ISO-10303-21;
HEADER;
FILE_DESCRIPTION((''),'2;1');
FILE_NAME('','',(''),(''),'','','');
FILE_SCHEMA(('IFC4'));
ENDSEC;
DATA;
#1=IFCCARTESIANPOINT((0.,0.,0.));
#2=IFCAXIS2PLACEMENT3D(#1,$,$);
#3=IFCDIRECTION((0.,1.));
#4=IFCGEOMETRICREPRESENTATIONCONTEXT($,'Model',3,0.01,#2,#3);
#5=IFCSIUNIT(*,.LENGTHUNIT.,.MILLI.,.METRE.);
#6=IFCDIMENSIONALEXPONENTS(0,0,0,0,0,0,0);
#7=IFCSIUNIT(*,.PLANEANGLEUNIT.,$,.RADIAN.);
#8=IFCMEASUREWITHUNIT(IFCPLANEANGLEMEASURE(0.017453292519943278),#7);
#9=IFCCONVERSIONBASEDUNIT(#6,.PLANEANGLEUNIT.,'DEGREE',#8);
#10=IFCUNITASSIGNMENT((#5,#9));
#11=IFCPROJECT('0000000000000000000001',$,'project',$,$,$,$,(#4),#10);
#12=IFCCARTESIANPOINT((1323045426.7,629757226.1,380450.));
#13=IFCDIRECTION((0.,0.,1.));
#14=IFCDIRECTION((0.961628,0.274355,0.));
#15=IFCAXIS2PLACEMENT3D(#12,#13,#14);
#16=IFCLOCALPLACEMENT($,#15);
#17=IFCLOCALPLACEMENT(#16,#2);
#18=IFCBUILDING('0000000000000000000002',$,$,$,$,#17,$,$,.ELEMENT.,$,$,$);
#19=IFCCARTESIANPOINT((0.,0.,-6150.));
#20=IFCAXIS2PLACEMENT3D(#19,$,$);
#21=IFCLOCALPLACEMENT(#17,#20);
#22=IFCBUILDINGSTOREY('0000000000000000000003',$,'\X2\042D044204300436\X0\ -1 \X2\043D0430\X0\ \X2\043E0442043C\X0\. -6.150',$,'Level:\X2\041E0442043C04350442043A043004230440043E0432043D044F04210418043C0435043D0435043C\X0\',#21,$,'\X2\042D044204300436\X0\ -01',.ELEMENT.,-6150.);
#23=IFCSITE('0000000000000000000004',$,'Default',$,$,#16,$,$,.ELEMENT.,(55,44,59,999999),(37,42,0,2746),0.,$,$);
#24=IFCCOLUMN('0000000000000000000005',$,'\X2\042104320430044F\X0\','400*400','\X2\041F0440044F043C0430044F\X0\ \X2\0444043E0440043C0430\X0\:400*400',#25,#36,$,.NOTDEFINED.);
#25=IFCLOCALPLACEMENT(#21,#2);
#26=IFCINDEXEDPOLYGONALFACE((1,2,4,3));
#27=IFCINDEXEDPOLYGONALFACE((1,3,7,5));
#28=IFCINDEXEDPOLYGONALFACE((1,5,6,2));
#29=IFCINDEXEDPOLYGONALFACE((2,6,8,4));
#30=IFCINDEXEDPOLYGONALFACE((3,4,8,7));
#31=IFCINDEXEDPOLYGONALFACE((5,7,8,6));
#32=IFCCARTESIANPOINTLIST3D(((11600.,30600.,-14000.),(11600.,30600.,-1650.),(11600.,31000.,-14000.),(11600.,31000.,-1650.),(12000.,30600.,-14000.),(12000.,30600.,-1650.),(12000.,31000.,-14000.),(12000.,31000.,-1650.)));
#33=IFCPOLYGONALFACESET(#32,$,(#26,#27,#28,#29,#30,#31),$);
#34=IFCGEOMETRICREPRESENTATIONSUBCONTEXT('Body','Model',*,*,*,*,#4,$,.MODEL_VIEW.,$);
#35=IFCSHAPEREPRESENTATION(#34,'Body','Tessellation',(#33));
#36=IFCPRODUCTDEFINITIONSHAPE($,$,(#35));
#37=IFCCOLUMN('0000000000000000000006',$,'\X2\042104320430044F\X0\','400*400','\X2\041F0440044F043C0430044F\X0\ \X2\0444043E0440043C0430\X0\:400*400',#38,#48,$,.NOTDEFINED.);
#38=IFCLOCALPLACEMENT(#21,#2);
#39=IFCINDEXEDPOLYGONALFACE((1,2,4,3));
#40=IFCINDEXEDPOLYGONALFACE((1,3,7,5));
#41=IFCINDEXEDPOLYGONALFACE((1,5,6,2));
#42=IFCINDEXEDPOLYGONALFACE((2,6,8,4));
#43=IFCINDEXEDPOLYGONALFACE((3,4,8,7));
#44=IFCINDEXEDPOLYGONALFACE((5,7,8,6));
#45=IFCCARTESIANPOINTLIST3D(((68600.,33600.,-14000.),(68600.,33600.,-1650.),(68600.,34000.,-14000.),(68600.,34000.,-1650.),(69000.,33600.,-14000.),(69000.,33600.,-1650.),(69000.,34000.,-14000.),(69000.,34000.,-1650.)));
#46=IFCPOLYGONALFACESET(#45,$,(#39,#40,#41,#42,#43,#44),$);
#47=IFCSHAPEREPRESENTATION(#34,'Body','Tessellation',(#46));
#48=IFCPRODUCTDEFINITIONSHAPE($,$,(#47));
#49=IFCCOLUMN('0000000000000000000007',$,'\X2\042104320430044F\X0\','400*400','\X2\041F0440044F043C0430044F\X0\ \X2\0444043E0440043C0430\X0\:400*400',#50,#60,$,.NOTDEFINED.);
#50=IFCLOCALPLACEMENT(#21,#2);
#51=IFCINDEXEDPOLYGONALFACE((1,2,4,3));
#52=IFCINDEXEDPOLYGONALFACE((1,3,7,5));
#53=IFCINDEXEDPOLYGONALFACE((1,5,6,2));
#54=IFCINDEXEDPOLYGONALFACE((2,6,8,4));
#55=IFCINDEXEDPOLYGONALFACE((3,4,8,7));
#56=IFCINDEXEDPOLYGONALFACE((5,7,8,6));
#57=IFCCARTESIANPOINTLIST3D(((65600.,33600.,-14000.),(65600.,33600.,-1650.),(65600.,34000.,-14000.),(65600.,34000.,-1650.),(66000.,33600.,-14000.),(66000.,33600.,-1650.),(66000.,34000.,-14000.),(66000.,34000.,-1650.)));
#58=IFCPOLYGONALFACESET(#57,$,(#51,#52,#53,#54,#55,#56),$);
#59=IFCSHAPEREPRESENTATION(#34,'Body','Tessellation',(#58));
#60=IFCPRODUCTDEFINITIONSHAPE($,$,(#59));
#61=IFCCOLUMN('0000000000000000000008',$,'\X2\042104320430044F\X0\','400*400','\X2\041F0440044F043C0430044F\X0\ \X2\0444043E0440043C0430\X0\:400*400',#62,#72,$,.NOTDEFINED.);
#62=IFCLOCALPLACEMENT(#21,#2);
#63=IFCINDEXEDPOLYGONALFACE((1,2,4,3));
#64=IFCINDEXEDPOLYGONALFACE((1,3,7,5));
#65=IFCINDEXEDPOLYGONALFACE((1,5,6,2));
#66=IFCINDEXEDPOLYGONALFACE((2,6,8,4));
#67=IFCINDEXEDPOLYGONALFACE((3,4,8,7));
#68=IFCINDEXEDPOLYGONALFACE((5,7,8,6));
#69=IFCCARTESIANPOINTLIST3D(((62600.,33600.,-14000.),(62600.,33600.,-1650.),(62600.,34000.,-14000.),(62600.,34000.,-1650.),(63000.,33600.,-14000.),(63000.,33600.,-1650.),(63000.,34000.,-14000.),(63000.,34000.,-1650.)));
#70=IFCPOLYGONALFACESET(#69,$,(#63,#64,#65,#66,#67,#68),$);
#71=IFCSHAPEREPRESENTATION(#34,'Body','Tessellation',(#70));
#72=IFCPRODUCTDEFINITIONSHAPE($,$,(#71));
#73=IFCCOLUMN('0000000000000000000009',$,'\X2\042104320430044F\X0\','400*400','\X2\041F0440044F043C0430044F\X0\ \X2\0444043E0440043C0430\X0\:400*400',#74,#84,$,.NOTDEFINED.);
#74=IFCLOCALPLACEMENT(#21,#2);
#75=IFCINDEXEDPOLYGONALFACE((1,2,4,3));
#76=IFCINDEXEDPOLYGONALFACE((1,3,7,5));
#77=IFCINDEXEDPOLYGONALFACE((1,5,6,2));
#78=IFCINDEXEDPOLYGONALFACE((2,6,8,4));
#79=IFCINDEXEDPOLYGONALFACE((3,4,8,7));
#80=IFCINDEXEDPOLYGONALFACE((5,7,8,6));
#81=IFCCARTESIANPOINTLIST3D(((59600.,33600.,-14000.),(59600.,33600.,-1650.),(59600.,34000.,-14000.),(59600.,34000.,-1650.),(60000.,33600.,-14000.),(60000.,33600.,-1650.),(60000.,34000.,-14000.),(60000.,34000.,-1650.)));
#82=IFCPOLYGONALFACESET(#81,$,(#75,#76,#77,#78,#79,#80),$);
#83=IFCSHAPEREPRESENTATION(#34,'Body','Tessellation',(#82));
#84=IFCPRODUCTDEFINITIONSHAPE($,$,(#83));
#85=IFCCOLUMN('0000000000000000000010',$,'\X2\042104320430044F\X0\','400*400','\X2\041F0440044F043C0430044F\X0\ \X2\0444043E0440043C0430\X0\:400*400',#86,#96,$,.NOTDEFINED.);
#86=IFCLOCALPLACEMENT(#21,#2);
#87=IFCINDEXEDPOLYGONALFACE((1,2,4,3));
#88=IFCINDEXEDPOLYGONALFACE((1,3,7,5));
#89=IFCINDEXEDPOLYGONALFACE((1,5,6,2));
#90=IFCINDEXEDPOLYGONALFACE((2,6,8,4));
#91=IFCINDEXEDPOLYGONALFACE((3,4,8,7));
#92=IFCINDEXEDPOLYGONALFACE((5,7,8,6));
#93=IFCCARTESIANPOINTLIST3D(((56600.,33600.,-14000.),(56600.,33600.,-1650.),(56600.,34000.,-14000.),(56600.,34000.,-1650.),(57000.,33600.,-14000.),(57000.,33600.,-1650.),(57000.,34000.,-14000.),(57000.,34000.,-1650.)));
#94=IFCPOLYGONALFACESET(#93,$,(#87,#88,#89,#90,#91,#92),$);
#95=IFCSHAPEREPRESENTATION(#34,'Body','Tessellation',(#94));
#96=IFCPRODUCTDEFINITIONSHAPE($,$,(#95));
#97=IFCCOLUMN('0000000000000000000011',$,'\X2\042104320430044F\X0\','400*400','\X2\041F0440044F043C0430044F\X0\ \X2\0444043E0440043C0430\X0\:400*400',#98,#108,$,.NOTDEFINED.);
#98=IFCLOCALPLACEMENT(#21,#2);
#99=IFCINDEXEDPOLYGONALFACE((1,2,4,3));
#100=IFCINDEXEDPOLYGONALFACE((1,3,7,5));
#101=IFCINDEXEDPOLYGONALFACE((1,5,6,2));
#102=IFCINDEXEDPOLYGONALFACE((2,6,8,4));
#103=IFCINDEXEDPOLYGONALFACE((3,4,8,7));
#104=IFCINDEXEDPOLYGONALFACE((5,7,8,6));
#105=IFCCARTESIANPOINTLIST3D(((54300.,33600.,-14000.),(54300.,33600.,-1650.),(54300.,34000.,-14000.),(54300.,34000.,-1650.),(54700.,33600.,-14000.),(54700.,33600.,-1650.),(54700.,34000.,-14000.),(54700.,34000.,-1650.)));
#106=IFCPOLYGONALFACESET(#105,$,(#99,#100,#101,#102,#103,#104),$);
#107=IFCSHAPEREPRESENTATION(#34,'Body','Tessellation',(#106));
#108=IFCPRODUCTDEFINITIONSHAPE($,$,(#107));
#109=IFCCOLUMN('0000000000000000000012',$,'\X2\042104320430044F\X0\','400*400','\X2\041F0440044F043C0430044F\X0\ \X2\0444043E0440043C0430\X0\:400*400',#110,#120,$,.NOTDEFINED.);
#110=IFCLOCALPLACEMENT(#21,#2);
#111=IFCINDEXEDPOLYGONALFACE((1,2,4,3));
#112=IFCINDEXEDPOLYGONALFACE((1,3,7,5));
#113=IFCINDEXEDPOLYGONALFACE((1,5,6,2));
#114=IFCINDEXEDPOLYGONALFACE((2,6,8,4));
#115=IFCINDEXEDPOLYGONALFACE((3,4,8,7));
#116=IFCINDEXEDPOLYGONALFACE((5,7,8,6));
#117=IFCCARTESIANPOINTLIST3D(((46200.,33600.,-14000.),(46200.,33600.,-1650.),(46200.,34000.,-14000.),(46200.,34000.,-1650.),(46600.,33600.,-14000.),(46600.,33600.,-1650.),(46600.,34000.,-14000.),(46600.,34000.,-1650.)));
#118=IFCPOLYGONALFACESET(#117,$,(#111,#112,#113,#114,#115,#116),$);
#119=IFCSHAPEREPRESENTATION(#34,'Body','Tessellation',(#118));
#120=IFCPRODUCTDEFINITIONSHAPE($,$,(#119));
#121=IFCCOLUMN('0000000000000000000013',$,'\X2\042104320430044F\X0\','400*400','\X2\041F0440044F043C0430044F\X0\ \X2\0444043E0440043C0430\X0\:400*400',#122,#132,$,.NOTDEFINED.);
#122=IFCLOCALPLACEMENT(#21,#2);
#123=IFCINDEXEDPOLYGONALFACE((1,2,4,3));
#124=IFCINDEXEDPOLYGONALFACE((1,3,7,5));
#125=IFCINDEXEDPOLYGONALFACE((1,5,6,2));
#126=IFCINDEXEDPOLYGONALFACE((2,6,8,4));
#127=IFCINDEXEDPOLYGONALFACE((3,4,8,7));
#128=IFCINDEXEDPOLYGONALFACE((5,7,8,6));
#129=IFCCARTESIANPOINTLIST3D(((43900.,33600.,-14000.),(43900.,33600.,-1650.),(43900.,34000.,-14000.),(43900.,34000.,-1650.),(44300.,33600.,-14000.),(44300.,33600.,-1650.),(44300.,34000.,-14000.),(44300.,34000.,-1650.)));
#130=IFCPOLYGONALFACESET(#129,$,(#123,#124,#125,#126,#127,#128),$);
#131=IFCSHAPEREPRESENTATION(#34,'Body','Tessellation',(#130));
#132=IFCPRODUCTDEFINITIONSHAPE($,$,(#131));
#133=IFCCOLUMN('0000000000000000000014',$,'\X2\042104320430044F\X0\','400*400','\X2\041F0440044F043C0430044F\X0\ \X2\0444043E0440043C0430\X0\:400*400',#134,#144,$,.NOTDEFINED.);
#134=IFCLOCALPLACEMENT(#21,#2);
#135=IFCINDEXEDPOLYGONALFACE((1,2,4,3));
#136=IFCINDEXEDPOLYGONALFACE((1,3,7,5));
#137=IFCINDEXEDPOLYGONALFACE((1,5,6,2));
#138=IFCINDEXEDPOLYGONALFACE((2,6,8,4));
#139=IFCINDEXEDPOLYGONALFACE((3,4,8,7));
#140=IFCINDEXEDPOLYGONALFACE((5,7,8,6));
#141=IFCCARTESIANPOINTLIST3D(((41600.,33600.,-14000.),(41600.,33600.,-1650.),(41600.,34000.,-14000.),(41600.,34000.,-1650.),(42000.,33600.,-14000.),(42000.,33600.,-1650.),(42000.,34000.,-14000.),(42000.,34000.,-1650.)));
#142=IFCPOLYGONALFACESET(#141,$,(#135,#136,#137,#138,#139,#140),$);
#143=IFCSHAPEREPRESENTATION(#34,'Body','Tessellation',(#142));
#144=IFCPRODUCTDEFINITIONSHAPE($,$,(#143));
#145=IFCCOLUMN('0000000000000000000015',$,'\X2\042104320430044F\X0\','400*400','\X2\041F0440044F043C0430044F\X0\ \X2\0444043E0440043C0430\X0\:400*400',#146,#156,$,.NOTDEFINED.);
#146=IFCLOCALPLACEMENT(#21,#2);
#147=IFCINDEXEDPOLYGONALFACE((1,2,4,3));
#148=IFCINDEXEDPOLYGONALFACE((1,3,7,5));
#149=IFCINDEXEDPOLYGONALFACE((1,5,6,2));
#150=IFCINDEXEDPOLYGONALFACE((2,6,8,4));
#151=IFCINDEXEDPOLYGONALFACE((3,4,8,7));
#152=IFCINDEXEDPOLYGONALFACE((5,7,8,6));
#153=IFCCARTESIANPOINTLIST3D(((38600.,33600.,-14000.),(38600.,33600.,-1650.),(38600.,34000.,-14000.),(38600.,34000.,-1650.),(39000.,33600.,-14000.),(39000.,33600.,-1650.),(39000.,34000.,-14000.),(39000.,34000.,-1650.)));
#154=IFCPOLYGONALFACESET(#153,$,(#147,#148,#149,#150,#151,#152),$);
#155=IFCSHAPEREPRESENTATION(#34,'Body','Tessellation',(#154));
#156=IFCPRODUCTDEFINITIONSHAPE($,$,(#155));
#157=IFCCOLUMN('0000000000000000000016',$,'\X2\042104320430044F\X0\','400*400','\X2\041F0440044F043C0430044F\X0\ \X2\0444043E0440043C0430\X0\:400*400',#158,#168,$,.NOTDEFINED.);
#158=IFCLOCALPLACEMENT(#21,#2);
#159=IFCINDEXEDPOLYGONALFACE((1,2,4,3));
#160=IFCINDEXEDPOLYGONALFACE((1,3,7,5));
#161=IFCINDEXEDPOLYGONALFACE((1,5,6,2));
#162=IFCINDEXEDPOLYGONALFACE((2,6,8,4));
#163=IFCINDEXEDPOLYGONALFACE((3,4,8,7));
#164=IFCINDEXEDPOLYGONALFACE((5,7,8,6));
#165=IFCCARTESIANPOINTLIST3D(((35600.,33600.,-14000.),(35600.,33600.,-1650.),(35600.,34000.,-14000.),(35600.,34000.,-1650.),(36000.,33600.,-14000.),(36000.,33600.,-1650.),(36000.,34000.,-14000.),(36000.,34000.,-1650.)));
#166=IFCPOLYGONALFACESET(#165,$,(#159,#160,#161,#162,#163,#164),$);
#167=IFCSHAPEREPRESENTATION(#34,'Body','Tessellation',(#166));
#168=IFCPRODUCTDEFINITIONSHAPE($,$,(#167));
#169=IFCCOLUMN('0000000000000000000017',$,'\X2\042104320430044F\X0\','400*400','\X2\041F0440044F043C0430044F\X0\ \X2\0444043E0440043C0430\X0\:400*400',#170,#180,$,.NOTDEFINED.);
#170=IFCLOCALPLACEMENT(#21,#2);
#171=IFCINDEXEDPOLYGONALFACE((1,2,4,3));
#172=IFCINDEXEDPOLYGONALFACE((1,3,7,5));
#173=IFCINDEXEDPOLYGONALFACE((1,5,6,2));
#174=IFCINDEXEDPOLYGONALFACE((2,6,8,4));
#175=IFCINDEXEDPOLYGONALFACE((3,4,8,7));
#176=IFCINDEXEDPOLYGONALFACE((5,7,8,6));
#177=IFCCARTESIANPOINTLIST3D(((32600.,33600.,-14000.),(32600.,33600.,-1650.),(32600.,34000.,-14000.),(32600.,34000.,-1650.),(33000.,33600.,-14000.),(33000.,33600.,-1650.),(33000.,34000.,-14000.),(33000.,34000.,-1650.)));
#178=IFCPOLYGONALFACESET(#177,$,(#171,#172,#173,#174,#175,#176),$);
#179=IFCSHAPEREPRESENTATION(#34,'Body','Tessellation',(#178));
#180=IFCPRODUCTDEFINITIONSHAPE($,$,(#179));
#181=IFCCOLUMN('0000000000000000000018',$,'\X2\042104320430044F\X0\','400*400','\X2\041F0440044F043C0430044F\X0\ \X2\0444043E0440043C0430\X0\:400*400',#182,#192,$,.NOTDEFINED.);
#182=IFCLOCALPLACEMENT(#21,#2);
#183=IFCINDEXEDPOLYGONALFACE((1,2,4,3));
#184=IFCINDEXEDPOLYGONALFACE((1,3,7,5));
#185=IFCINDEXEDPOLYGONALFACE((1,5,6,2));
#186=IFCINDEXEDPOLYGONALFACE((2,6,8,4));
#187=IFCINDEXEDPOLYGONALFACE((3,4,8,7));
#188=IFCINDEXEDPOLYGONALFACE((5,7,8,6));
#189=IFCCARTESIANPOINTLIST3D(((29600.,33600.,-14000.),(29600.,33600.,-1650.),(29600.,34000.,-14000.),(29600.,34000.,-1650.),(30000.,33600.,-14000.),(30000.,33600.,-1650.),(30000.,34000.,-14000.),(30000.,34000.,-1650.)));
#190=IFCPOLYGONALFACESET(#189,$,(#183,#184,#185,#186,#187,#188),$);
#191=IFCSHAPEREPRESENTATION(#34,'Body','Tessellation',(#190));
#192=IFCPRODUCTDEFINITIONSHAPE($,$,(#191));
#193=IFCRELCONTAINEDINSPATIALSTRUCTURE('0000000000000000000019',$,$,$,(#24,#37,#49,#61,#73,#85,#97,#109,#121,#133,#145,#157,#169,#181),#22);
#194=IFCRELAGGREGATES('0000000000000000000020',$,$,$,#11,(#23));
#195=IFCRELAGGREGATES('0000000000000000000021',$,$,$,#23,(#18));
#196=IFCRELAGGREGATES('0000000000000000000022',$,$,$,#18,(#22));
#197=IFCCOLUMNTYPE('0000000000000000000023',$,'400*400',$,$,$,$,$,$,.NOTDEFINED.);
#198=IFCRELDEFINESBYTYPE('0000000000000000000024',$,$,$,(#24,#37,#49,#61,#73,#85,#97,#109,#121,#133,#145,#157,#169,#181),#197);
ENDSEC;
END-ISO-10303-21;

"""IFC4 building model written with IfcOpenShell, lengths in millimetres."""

from ifc_helpers import new_model, entity, si_unit, converted_unit, direction, frame, origin, place, context, subcontext, project, spatial, indexed_curve, outline, extrude, type_object, element, save


model = new_model("IFC4")

# Units and contexts
model_context = context("Model", 3, precision=0.01, world=origin(), true_north=direction((0.0, 1.0)))
body_context = subcontext(model_context, "Body", "Model", "MODEL_VIEW")
ifc_project = project(units=[si_unit("LENGTHUNIT", "METRE", prefix="MILLI"), converted_unit("PLANEANGLEUNIT", "DEGREE", entity("IfcPlaneAngleMeasure", 0.017453292519943278), si_unit("PLANEANGLEUNIT", "RADIAN"), dimensions=[0, 0, 0, 0, 0, 0, 0])], contexts=[model_context])

# Site, building, storey
site_placement = place(None, frame((1323045426.7, 629757226.1, 380450.0), z_axis=(0.0, 0.0, 1.0), x_axis=(0.961628, 0.274355, 0.0)))
site = spatial("IfcSite", under=ifc_project, at=site_placement, Name="Default", CompositionType="ELEMENT", RefLatitude=(55, 44, 59, 999999), RefLongitude=(37, 42, 0, 2746), RefElevation=0.0)
building_placement = place(site_placement, origin())
building = spatial("IfcBuilding", under=site, at=building_placement, CompositionType="ELEMENT")
storey_placement = place(building_placement, frame((0.0, 0.0, -6150.0)))
storey = spatial("IfcBuildingStorey", under=building, at=storey_placement, Name="Этаж -1 на отм. -6.150", ObjectType="Level:ОтметкаУровняСИменем", LongName="Этаж -01", CompositionType="ELEMENT", Elevation=-6150.0)

# Columns
column_type = type_object("IfcColumnType", Name="400*400", PredefinedType="NOTDEFINED")
column_1_placement = place(storey_placement, origin())
element("IfcColumn", 1, at=column_1_placement, inside=storey, type_object=column_type, Name="Свая", Description="400*400", ObjectType="Прямая форма:400*400", PredefinedType="NOTDEFINED", context=body_context, shape_type="SweptSolid", body=[
    extrude(outline(indexed_curve([(-200.0, -200.0), (200.0, -200.0), (200.0, 200.0), (-200.0, 200.0), (-200.0, -200.0)], self_intersect=False)), frame((11800.0, 30800.0, -14000.0), z_axis=(0.0, 0.0, 1.0), x_axis=(0.0, 1.0, 0.0)), (0.0, 0.0, 1.0), 12350.0),
])
column_2_placement = place(storey_placement, origin())
element("IfcColumn", 2, at=column_2_placement, inside=storey, type_object=column_type, Name="Свая", Description="400*400", ObjectType="Прямая форма:400*400", PredefinedType="NOTDEFINED", context=body_context, shape_type="SweptSolid", body=[
    extrude(outline(indexed_curve([(-200.0, -200.0), (200.0, -200.0), (200.0, 200.0), (-200.0, 200.0), (-200.0, -200.0)], self_intersect=False)), frame((68800.0, 33800.0, -14000.0), z_axis=(0.0, 0.0, 1.0), x_axis=(0.0, 1.0, 0.0)), (0.0, 0.0, 1.0), 12350.0),
])
column_3_placement = place(storey_placement, origin())
element("IfcColumn", 3, at=column_3_placement, inside=storey, type_object=column_type, Name="Свая", Description="400*400", ObjectType="Прямая форма:400*400", PredefinedType="NOTDEFINED", context=body_context, shape_type="SweptSolid", body=[
    extrude(outline(indexed_curve([(-200.0, -200.0), (200.0, -200.0), (200.0, 200.0), (-200.0, 200.0), (-200.0, -200.0)], self_intersect=False)), frame((65800.0, 33800.0, -14000.0), z_axis=(0.0, 0.0, 1.0), x_axis=(0.0, 1.0, 0.0)), (0.0, 0.0, 1.0), 12350.0),
])
column_4_placement = place(storey_placement, origin())
element("IfcColumn", 4, at=column_4_placement, inside=storey, type_object=column_type, Name="Свая", Description="400*400", ObjectType="Прямая форма:400*400", PredefinedType="NOTDEFINED", context=body_context, shape_type="SweptSolid", body=[
    extrude(outline(indexed_curve([(-200.0, -200.0), (200.0, -200.0), (200.0, 200.0), (-200.0, 200.0), (-200.0, -200.0)], self_intersect=False)), frame((62800.0, 33800.0, -14000.0), z_axis=(0.0, 0.0, 1.0), x_axis=(0.0, 1.0, 0.0)), (0.0, 0.0, 1.0), 12350.0),
])
column_5_placement = place(storey_placement, origin())
element("IfcColumn", 5, at=column_5_placement, inside=storey, type_object=column_type, Name="Свая", Description="400*400", ObjectType="Прямая форма:400*400", PredefinedType="NOTDEFINED", context=body_context, shape_type="SweptSolid", body=[
    extrude(outline(indexed_curve([(-200.0, -200.0), (200.0, -200.0), (200.0, 200.0), (-200.0, 200.0), (-200.0, -200.0)], self_intersect=False)), frame((59800.0, 33800.0, -14000.0), z_axis=(0.0, 0.0, 1.0), x_axis=(0.0, 1.0, 0.0)), (0.0, 0.0, 1.0), 12350.0),
])
column_6_placement = place(storey_placement, origin())
element("IfcColumn", 6, at=column_6_placement, inside=storey, type_object=column_type, Name="Свая", Description="400*400", ObjectType="Прямая форма:400*400", PredefinedType="NOTDEFINED", context=body_context, shape_type="SweptSolid", body=[
    extrude(outline(indexed_curve([(-200.0, -200.0), (200.0, -200.0), (200.0, 200.0), (-200.0, 200.0), (-200.0, -200.0)], self_intersect=False)), frame((56800.0, 33800.0, -14000.0), z_axis=(0.0, 0.0, 1.0), x_axis=(0.0, 1.0, 0.0)), (0.0, 0.0, 1.0), 12350.0),
])
column_7_placement = place(storey_placement, origin())
element("IfcColumn", 7, at=column_7_placement, inside=storey, type_object=column_type, Name="Свая", Description="400*400", ObjectType="Прямая форма:400*400", PredefinedType="NOTDEFINED", context=body_context, shape_type="SweptSolid", body=[
    extrude(outline(indexed_curve([(-200.0, -200.0), (200.0, -200.0), (200.0, 200.0), (-200.0, 200.0), (-200.0, -200.0)], self_intersect=False)), frame((54500.0, 33800.0, -14000.0), z_axis=(0.0, 0.0, 1.0), x_axis=(0.0, 1.0, 0.0)), (0.0, 0.0, 1.0), 12350.0),
])
column_8_placement = place(storey_placement, origin())
element("IfcColumn", 8, at=column_8_placement, inside=storey, type_object=column_type, Name="Свая", Description="400*400", ObjectType="Прямая форма:400*400", PredefinedType="NOTDEFINED", context=body_context, shape_type="SweptSolid", body=[
    extrude(outline(indexed_curve([(-200.0, -200.0), (200.0, -200.0), (200.0, 200.0), (-200.0, 200.0), (-200.0, -200.0)], self_intersect=False)), frame((46400.0, 33800.0, -14000.0), z_axis=(0.0, 0.0, 1.0), x_axis=(0.0, 1.0, 0.0)), (0.0, 0.0, 1.0), 12350.0),
])
column_9_placement = place(storey_placement, origin())
element("IfcColumn", 9, at=column_9_placement, inside=storey, type_object=column_type, Name="Свая", Description="400*400", ObjectType="Прямая форма:400*400", PredefinedType="NOTDEFINED", context=body_context, shape_type="SweptSolid", body=[
    extrude(outline(indexed_curve([(-200.0, -200.0), (200.0, -200.0), (200.0, 200.0), (-200.0, 200.0), (-200.0, -200.0)], self_intersect=False)), frame((44100.0, 33800.0, -14000.0), z_axis=(0.0, 0.0, 1.0), x_axis=(0.0, 1.0, 0.0)), (0.0, 0.0, 1.0), 12350.0),
])
column_10_placement = place(storey_placement, origin())
element("IfcColumn", 10, at=column_10_placement, inside=storey, type_object=column_type, Name="Свая", Description="400*400", ObjectType="Прямая форма:400*400", PredefinedType="NOTDEFINED", context=body_context, shape_type="SweptSolid", body=[
    extrude(outline(indexed_curve([(-200.0, -200.0), (200.0, -200.0), (200.0, 200.0), (-200.0, 200.0), (-200.0, -200.0)], self_intersect=False)), frame((41800.0, 33800.0, -14000.0), z_axis=(0.0, 0.0, 1.0), x_axis=(0.0, 1.0, 0.0)), (0.0, 0.0, 1.0), 12350.0),
])
column_11_placement = place(storey_placement, origin())
element("IfcColumn", 11, at=column_11_placement, inside=storey, type_object=column_type, Name="Свая", Description="400*400", ObjectType="Прямая форма:400*400", PredefinedType="NOTDEFINED", context=body_context, shape_type="SweptSolid", body=[
    extrude(outline(indexed_curve([(-200.0, -200.0), (200.0, -200.0), (200.0, 200.0), (-200.0, 200.0), (-200.0, -200.0)], self_intersect=False)), frame((38800.0, 33800.0, -14000.0), z_axis=(0.0, 0.0, 1.0), x_axis=(0.0, 1.0, 0.0)), (0.0, 0.0, 1.0), 12350.0),
])
column_12_placement = place(storey_placement, origin())
element("IfcColumn", 12, at=column_12_placement, inside=storey, type_object=column_type, Name="Свая", Description="400*400", ObjectType="Прямая форма:400*400", PredefinedType="NOTDEFINED", context=body_context, shape_type="SweptSolid", body=[
    extrude(outline(indexed_curve([(-200.0, -200.0), (200.0, -200.0), (200.0, 200.0), (-200.0, 200.0), (-200.0, -200.0)], self_intersect=False)), frame((35800.0, 33800.0, -14000.0), z_axis=(0.0, 0.0, 1.0), x_axis=(0.0, 1.0, 0.0)), (0.0, 0.0, 1.0), 12350.0),
])
column_13_placement = place(storey_placement, origin())
element("IfcColumn", 13, at=column_13_placement, inside=storey, type_object=column_type, Name="Свая", Description="400*400", ObjectType="Прямая форма:400*400", PredefinedType="NOTDEFINED", context=body_context, shape_type="SweptSolid", body=[
    extrude(outline(indexed_curve([(-200.0, -200.0), (200.0, -200.0), (200.0, 200.0), (-200.0, 200.0), (-200.0, -200.0)], self_intersect=False)), frame((32800.0, 33800.0, -14000.0), z_axis=(0.0, 0.0, 1.0), x_axis=(0.0, 1.0, 0.0)), (0.0, 0.0, 1.0), 12350.0),
])
column_14_placement = place(storey_placement, origin())
element("IfcColumn", 14, at=column_14_placement, inside=storey, type_object=column_type, Name="Свая", Description="400*400", ObjectType="Прямая форма:400*400", PredefinedType="NOTDEFINED", context=body_context, shape_type="SweptSolid", body=[
    extrude(outline(indexed_curve([(-200.0, -200.0), (200.0, -200.0), (200.0, 200.0), (-200.0, 200.0), (-200.0, -200.0)], self_intersect=False)), frame((29800.0, 33800.0, -14000.0), z_axis=(0.0, 0.0, 1.0), x_axis=(0.0, 1.0, 0.0)), (0.0, 0.0, 1.0), 12350.0),
])

save(model, "model.ifc")
